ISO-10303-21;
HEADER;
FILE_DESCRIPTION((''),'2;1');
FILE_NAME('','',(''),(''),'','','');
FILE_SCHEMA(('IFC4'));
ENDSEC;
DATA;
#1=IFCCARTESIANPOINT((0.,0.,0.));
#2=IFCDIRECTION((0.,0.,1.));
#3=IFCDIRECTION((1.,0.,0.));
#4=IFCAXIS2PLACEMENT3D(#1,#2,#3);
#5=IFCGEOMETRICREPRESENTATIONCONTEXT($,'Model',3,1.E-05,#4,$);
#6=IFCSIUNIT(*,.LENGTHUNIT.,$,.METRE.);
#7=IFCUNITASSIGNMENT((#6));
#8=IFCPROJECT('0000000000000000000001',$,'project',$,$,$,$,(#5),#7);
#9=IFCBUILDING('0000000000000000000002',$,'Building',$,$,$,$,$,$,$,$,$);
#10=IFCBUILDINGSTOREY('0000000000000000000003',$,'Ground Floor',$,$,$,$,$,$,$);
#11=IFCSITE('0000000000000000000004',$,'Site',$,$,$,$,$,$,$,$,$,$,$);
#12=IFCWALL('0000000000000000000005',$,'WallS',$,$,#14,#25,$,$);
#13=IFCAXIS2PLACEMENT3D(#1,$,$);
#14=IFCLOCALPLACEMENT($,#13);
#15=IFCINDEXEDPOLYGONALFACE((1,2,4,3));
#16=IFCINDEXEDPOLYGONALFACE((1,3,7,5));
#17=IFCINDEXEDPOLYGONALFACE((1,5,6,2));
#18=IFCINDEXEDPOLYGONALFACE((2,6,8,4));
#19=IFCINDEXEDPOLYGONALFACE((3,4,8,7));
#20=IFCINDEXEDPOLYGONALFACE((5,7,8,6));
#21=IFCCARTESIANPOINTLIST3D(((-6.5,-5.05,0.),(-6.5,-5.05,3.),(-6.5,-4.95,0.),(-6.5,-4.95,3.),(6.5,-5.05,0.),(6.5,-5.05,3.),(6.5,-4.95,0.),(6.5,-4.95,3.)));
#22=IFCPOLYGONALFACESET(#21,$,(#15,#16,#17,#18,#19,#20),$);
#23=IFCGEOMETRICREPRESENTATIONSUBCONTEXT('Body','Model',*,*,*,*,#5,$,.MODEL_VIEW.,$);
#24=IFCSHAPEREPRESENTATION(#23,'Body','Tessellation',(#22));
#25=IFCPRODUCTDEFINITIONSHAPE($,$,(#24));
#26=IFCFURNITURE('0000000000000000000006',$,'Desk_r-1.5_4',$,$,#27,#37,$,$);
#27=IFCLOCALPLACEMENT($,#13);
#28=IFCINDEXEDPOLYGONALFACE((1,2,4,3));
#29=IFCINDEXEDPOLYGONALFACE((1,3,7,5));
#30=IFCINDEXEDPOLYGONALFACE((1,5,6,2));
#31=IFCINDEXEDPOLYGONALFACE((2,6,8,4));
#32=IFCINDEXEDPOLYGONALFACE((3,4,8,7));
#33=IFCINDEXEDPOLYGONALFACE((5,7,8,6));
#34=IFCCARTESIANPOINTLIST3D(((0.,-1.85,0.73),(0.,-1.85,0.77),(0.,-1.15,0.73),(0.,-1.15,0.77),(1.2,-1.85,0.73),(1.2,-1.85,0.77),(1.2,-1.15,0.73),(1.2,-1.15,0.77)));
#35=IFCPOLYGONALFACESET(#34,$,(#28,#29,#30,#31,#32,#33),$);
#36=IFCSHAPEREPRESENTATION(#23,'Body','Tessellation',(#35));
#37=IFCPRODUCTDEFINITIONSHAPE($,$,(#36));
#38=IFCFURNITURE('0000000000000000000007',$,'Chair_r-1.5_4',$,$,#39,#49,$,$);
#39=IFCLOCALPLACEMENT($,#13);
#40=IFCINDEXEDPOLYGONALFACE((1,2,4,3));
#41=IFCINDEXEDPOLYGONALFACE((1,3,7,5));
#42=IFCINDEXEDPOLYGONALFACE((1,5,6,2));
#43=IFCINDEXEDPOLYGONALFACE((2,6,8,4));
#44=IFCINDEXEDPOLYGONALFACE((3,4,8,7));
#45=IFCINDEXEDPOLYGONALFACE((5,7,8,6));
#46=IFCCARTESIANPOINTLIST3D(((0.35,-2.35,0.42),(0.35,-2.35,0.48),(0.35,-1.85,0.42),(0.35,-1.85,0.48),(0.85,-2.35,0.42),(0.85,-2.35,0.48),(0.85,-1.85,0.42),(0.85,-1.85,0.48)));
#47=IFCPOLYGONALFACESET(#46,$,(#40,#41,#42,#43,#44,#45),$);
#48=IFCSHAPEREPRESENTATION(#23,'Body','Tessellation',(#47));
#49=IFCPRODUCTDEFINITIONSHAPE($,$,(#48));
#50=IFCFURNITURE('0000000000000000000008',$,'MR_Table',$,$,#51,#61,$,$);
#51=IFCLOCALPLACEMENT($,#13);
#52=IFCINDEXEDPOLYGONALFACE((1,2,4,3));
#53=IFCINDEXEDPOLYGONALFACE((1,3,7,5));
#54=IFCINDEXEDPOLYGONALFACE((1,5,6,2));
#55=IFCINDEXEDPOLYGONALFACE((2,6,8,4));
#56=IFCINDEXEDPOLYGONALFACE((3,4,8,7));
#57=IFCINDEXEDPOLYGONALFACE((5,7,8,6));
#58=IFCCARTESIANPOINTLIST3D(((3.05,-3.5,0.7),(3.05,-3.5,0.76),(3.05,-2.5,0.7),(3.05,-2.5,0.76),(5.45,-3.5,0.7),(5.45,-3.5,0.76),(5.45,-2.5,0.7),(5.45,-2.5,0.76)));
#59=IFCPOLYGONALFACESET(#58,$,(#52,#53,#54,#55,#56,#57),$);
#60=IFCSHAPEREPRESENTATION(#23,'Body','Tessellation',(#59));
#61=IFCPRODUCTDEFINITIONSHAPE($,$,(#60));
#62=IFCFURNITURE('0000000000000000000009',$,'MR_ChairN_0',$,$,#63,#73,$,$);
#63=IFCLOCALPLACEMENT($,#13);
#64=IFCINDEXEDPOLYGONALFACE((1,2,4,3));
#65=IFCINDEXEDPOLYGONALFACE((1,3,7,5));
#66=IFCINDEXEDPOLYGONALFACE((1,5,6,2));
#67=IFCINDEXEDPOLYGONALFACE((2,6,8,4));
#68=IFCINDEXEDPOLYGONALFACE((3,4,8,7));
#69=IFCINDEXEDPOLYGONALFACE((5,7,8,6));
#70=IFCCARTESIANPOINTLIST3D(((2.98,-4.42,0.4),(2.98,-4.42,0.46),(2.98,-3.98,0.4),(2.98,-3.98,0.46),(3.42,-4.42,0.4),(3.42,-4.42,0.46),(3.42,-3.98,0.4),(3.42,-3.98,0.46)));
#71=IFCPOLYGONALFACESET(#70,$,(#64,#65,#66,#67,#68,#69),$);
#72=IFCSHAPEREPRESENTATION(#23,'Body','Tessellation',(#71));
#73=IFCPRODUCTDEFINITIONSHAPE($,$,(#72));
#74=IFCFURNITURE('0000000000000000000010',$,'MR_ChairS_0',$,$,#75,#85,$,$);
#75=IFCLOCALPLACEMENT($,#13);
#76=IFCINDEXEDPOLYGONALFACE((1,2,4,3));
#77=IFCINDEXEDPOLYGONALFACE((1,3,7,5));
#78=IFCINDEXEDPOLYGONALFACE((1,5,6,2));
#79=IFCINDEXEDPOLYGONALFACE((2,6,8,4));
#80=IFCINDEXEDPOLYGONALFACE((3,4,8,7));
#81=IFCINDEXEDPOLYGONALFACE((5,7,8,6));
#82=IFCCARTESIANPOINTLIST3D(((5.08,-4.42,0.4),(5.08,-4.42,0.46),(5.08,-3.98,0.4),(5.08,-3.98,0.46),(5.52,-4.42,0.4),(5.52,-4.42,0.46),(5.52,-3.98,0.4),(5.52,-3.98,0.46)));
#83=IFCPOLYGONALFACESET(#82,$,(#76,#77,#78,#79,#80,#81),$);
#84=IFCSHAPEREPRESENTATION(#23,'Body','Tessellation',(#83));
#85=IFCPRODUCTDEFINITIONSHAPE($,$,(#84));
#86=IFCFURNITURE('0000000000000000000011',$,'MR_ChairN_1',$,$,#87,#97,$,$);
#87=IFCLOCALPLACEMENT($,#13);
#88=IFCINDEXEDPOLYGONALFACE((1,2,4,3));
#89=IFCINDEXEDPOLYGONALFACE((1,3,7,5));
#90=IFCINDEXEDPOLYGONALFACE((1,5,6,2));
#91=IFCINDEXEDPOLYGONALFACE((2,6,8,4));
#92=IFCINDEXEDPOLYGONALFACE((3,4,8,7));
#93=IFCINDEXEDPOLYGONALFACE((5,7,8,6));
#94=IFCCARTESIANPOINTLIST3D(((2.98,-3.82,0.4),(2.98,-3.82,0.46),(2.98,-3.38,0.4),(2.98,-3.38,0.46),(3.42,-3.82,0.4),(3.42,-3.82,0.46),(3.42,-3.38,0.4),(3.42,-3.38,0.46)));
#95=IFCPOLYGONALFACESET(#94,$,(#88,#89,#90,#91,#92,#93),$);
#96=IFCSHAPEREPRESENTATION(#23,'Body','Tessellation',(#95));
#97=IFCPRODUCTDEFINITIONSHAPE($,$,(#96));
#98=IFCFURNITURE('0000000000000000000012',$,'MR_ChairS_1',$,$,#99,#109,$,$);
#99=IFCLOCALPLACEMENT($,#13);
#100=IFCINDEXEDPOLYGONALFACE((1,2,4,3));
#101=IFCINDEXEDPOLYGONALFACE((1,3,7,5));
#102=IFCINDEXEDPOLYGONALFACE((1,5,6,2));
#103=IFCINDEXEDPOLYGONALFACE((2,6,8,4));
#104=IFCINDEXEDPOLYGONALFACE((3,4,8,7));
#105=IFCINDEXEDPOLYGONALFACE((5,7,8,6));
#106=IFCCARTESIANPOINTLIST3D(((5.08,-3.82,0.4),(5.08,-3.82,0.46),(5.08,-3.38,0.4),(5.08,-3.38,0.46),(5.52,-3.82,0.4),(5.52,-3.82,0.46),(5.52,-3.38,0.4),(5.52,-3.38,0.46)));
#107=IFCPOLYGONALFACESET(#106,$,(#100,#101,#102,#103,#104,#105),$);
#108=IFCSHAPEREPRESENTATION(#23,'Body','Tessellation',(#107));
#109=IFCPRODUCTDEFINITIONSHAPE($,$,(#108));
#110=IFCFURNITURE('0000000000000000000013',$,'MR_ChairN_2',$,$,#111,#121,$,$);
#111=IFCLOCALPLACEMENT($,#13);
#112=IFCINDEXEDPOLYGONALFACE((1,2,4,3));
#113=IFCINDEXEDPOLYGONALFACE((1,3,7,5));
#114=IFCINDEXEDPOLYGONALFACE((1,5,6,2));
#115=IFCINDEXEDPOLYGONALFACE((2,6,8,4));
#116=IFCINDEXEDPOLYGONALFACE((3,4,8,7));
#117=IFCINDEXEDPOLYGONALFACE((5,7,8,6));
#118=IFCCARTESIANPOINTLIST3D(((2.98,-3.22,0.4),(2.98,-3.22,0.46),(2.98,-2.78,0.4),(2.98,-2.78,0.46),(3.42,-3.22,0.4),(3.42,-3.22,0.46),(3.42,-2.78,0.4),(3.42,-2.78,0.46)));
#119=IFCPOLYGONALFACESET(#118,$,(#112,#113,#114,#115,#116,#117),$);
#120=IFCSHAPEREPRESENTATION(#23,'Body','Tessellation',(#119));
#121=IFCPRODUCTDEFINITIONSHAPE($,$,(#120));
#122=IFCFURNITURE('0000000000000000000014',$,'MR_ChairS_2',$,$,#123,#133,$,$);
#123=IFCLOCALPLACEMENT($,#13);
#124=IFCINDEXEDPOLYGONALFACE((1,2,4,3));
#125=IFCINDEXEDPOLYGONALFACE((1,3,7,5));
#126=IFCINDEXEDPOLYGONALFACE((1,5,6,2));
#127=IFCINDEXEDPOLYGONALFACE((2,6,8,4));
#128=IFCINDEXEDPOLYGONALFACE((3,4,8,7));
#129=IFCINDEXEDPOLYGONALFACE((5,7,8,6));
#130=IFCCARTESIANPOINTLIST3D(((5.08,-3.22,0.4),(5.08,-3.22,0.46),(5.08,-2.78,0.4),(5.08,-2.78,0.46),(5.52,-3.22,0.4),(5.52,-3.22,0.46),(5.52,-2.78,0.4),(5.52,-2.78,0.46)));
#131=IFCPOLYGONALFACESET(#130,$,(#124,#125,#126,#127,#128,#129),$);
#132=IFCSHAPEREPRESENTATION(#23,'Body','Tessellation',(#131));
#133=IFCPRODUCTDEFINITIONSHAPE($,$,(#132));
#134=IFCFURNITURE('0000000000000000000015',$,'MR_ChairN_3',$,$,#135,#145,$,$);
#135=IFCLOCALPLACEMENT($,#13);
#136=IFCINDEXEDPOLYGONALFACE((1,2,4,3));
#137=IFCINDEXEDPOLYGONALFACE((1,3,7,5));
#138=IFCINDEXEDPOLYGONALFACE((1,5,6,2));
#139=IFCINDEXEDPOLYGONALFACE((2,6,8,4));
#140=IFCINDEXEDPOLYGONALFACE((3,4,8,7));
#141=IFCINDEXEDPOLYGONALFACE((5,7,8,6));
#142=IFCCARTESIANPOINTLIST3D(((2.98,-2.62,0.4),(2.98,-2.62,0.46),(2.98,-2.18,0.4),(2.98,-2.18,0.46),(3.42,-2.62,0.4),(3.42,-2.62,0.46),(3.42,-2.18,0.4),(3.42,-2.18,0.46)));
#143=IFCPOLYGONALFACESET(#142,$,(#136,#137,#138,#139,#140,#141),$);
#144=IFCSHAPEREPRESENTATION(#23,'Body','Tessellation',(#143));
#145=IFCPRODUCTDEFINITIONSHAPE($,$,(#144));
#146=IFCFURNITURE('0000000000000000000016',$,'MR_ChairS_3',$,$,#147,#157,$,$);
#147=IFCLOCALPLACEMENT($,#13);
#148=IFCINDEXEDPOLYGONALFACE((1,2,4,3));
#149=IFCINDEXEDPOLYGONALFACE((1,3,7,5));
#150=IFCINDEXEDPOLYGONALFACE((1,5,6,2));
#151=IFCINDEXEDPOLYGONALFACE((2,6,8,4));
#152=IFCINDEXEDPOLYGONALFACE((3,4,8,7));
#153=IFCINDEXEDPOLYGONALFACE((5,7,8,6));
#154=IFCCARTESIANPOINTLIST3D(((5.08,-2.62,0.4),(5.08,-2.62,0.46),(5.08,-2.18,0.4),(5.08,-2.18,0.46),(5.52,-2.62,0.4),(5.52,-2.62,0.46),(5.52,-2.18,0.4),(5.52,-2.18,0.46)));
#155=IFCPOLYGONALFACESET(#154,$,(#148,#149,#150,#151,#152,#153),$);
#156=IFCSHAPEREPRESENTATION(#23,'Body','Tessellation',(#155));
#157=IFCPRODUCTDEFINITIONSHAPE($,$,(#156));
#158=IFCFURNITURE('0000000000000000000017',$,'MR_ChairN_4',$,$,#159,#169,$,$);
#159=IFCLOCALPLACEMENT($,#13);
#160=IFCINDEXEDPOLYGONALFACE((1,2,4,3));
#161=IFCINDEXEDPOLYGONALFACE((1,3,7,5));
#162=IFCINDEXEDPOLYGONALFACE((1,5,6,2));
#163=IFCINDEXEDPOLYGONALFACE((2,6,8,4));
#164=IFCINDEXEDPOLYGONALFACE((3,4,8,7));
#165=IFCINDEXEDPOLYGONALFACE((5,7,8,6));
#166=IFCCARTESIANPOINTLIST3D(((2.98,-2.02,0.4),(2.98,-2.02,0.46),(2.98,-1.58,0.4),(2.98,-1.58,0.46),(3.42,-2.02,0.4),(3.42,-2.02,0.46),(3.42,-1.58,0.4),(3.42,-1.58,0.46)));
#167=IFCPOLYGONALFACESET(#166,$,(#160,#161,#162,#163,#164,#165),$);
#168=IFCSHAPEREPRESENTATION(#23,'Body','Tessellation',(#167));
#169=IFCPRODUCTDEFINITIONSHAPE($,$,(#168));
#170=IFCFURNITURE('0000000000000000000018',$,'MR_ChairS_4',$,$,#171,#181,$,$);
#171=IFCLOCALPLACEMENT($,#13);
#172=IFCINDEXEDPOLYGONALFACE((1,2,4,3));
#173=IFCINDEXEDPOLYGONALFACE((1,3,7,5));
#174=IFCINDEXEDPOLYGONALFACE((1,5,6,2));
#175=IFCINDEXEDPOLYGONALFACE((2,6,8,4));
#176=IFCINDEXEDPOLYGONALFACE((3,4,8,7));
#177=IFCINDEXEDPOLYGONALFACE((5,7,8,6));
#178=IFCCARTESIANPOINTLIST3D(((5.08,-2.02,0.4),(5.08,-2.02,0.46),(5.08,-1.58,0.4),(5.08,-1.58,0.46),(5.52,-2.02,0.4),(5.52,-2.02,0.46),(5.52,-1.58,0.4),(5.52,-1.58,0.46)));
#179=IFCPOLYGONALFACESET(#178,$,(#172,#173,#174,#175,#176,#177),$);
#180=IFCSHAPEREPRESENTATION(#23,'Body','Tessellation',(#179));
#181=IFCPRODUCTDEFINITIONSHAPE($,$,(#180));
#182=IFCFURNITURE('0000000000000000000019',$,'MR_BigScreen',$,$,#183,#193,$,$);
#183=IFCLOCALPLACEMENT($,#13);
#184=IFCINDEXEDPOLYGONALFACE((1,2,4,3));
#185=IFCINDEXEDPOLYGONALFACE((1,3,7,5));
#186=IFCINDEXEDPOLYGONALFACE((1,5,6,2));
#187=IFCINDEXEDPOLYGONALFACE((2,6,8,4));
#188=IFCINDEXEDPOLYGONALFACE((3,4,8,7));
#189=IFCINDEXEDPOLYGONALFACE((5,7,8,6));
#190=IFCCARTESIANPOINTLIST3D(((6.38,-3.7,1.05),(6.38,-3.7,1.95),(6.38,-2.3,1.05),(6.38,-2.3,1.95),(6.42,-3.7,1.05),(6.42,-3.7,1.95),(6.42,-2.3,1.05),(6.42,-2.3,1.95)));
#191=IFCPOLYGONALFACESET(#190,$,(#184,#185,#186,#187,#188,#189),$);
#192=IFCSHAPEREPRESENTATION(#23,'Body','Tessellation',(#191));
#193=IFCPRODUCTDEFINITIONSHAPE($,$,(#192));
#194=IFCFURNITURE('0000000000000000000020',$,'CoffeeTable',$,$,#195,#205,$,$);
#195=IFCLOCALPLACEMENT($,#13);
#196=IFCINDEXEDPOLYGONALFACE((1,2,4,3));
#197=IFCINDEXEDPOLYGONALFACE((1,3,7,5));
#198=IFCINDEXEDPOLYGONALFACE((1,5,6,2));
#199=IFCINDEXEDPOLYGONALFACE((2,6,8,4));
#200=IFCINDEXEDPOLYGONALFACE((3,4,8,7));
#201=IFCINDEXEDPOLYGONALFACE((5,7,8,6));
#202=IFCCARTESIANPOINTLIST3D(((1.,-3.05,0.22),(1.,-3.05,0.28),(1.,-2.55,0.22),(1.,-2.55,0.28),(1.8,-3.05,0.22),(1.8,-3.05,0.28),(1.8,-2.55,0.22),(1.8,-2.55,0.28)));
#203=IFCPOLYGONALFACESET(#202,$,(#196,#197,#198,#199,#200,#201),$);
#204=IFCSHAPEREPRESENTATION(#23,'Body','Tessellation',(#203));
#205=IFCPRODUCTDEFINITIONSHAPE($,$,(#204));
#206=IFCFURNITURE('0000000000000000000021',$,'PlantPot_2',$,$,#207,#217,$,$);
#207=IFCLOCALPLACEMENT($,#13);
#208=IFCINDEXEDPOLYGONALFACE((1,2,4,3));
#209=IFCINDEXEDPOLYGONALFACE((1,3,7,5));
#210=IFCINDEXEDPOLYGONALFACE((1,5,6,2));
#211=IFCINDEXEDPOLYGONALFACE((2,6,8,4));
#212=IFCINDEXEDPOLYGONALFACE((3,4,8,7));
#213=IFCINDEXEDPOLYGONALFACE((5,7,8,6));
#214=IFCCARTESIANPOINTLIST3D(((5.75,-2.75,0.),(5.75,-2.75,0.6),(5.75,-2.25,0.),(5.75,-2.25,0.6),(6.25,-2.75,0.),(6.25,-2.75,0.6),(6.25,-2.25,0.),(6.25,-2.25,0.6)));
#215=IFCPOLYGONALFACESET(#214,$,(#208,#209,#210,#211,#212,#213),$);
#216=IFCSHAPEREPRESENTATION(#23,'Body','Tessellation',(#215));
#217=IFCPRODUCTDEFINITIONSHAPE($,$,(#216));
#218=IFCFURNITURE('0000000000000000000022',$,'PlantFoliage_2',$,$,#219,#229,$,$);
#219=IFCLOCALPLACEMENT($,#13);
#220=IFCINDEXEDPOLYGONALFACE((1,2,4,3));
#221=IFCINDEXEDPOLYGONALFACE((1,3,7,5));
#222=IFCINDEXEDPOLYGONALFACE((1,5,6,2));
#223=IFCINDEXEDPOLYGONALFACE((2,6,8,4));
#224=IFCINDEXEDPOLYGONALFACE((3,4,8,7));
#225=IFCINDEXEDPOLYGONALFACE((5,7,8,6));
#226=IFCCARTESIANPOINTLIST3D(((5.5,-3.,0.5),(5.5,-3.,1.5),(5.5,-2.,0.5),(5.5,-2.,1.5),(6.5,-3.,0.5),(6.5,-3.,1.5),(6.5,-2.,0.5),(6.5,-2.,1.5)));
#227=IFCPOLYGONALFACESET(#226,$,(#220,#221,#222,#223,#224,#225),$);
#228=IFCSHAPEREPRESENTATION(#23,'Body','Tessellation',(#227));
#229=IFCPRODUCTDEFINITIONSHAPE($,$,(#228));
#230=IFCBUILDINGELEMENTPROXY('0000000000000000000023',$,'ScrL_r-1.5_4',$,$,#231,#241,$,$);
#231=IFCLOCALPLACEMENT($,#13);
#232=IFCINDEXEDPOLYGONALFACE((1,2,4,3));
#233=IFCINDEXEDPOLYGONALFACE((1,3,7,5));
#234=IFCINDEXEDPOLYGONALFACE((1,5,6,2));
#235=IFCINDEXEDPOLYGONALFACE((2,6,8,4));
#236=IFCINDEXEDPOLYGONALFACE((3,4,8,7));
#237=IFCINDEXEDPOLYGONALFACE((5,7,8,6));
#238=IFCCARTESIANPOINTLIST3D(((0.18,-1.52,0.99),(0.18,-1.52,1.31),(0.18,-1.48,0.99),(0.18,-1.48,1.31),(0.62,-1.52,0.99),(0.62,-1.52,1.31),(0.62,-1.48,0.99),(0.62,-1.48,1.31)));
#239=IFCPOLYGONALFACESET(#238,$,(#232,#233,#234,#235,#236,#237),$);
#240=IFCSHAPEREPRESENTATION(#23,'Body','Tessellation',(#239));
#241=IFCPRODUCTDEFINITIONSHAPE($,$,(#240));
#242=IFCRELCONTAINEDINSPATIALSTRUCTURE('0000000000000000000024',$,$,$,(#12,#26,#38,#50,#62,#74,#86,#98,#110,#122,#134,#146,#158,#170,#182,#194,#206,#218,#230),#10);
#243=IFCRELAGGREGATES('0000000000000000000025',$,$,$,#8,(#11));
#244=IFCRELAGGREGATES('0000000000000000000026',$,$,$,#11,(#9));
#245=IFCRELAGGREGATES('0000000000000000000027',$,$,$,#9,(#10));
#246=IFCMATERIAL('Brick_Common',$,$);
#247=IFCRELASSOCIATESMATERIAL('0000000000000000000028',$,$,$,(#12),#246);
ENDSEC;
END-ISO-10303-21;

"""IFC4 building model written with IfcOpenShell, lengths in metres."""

from ifc_helpers import new_model, si_unit, frame, origin_with_axes, origin_2d, place, context, subcontext, project, spatial, rectangle, extrude, material, element, save


model = new_model("IFC4")

# Units and contexts
model_context = context("Model", 3, precision=1e-05, world=origin_with_axes())
body_context = subcontext(model_context, "Body", "Model", "MODEL_VIEW")
ifc_project = project(units=[si_unit("LENGTHUNIT", "METRE")], contexts=[model_context])

# Site, building, storey
site = spatial("IfcSite", under=ifc_project, Name="Site")
building = spatial("IfcBuilding", under=site, Name="Building")
storey = spatial("IfcBuildingStorey", under=building, Name="Ground Floor")

# Wall
ifc_material = material(Name="Brick_Common")
wall_placement = place(None, frame((0.0, -5.0, 1.5), z_axis=(0.0, 0.0, 1.0), x_axis=(1.0, 0.0, 0.0)))
element("IfcWall", 1, at=wall_placement, inside=storey, material=ifc_material, Name="WallS", context=body_context, shape_type="SweptSolid", body=[
    extrude(rectangle(XDim=13.0, YDim=0.1, at=origin_2d()), frame((0.0, 0.0, -1.5)), (0.0, 0.0, 1.0), 3.0),
])

# Furniture
furniture_1_placement = place(None, frame((0.6, -1.5, 0.75), z_axis=(0.0, 0.0, 1.0), x_axis=(1.0, 0.0, 0.0)))
element("IfcFurniture", 2, at=furniture_1_placement, inside=storey, Name="Desk_r-1.5_4", context=body_context, shape_type="SweptSolid", body=[
    extrude(rectangle(XDim=1.2, YDim=0.7, at=origin_2d()), frame((0.0, 0.0, -0.02)), (0.0, 0.0, 1.0), 0.04),
])
furniture_2_placement = place(None, frame((0.6, -2.1, 0.45), z_axis=(0.0, 0.0, 1.0), x_axis=(1.0, 0.0, 0.0)))
element("IfcFurniture", 3, at=furniture_2_placement, inside=storey, Name="Chair_r-1.5_4", context=body_context, shape_type="SweptSolid", body=[
    extrude(rectangle(XDim=0.5, YDim=0.5, at=origin_2d()), frame((0.0, 0.0, -0.03)), (0.0, 0.0, 1.0), 0.06),
])
furniture_3_placement = place(None, frame((4.25, -3.0, 0.73), z_axis=(0.0, 0.0, 1.0), x_axis=(1.0, 0.0, 0.0)))
element("IfcFurniture", 4, at=furniture_3_placement, inside=storey, Name="MR_Table", context=body_context, shape_type="SweptSolid", body=[
    extrude(rectangle(XDim=2.4, YDim=1.0, at=origin_2d()), frame((0.0, 0.0, -0.03)), (0.0, 0.0, 1.0), 0.06),
])
for number, where, z_axis, x_axis, name in (
    (5, (3.2, -4.2, 0.43), (0.0, 0.0, 1.0), (1.0, 0.0, 0.0), "MR_ChairN_0"),
    (6, (5.3, -4.2, 0.43), (0.0, 0.0, 1.0), (1.0, 0.0, 0.0), "MR_ChairS_0"),
    (7, (3.2, -3.6, 0.43), (0.0, 0.0, 1.0), (1.0, 0.0, 0.0), "MR_ChairN_1"),
    (8, (5.3, -3.6, 0.43), (0.0, 0.0, 1.0), (1.0, 0.0, 0.0), "MR_ChairS_1"),
    (9, (3.2, -3.0, 0.43), (0.0, 0.0, 1.0), (1.0, 0.0, 0.0), "MR_ChairN_2"),
    (10, (5.3, -3.0, 0.43), (0.0, 0.0, 1.0), (1.0, 0.0, 0.0), "MR_ChairS_2"),
    (11, (3.2, -2.4, 0.43), (0.0, 0.0, 1.0), (1.0, 0.0, 0.0), "MR_ChairN_3"),
    (12, (5.3, -2.4, 0.43), (0.0, 0.0, 1.0), (1.0, 0.0, 0.0), "MR_ChairS_3"),
    (13, (3.2, -1.8, 0.43), (0.0, 0.0, 1.0), (1.0, 0.0, 0.0), "MR_ChairN_4"),
    (14, (5.3, -1.8, 0.43), (0.0, 0.0, 1.0), (1.0, 0.0, 0.0), "MR_ChairS_4"),
):
    element("IfcFurniture", number, at=place(None, frame(where, z_axis=z_axis, x_axis=x_axis)), inside=storey, Name=name, context=body_context, shape_type="SweptSolid", body=[
        extrude(rectangle(XDim=0.44, YDim=0.44, at=origin_2d()), frame((0.0, 0.0, -0.03)), (0.0, 0.0, 1.0), 0.06),
    ])
furniture_4_placement = place(None, frame((6.4, -3.0, 1.5), z_axis=(0.0, 0.0, 1.0), x_axis=(1.0, 0.0, 0.0)))
element("IfcFurniture", 15, at=furniture_4_placement, inside=storey, Name="MR_BigScreen", context=body_context, shape_type="SweptSolid", body=[
    extrude(rectangle(XDim=0.04, YDim=1.4, at=origin_2d()), frame((0.0, 0.0, -0.45)), (0.0, 0.0, 1.0), 0.9),
])
furniture_5_placement = place(None, frame((1.4, -2.8, 0.25), z_axis=(0.0, 0.0, 1.0), x_axis=(1.0, 0.0, 0.0)))
element("IfcFurniture", 16, at=furniture_5_placement, inside=storey, Name="CoffeeTable", context=body_context, shape_type="SweptSolid", body=[
    extrude(rectangle(XDim=0.8, YDim=0.5, at=origin_2d()), frame((0.0, 0.0, -0.03)), (0.0, 0.0, 1.0), 0.06),
])
furniture_6_placement = place(None, frame((6.0, -2.5, 0.3), z_axis=(0.0, 0.0, 1.0), x_axis=(1.0, 0.0, 0.0)))
element("IfcFurniture", 17, at=furniture_6_placement, inside=storey, Name="PlantPot_2", context=body_context, shape_type="SweptSolid", body=[
    extrude(rectangle(XDim=0.5, YDim=0.5, at=origin_2d()), frame((0.0, 0.0, -0.3)), (0.0, 0.0, 1.0), 0.6),
])
furniture_7_placement = place(None, frame((6.0, -2.5, 1.0), z_axis=(0.0, 0.0, 1.0), x_axis=(1.0, 0.0, 0.0)))
element("IfcFurniture", 18, at=furniture_7_placement, inside=storey, Name="PlantFoliage_2", context=body_context, shape_type="SweptSolid", body=[
    extrude(rectangle(XDim=1.0, YDim=1.0, at=origin_2d()), frame((0.0, 0.0, -0.5)), (0.0, 0.0, 1.0), 1.0),
])

# Building element proxy
for number, where, z_axis, x_axis, name in (
    (19, (0.4, -1.5, 1.15), (0.0, 0.0, 1.0), (1.0, 0.0, 0.0), "ScrL_r-1.5_4"),
):
    element("IfcBuildingElementProxy", number, at=place(None, frame(where, z_axis=z_axis, x_axis=x_axis)), inside=storey, Name=name, context=body_context, shape_type="SweptSolid", body=[
        extrude(rectangle(XDim=0.44, YDim=0.04, at=origin_2d()), frame((0.0, 0.0, -0.16)), (0.0, 0.0, 1.0), 0.32),
    ])

save(model, "model.ifc")
